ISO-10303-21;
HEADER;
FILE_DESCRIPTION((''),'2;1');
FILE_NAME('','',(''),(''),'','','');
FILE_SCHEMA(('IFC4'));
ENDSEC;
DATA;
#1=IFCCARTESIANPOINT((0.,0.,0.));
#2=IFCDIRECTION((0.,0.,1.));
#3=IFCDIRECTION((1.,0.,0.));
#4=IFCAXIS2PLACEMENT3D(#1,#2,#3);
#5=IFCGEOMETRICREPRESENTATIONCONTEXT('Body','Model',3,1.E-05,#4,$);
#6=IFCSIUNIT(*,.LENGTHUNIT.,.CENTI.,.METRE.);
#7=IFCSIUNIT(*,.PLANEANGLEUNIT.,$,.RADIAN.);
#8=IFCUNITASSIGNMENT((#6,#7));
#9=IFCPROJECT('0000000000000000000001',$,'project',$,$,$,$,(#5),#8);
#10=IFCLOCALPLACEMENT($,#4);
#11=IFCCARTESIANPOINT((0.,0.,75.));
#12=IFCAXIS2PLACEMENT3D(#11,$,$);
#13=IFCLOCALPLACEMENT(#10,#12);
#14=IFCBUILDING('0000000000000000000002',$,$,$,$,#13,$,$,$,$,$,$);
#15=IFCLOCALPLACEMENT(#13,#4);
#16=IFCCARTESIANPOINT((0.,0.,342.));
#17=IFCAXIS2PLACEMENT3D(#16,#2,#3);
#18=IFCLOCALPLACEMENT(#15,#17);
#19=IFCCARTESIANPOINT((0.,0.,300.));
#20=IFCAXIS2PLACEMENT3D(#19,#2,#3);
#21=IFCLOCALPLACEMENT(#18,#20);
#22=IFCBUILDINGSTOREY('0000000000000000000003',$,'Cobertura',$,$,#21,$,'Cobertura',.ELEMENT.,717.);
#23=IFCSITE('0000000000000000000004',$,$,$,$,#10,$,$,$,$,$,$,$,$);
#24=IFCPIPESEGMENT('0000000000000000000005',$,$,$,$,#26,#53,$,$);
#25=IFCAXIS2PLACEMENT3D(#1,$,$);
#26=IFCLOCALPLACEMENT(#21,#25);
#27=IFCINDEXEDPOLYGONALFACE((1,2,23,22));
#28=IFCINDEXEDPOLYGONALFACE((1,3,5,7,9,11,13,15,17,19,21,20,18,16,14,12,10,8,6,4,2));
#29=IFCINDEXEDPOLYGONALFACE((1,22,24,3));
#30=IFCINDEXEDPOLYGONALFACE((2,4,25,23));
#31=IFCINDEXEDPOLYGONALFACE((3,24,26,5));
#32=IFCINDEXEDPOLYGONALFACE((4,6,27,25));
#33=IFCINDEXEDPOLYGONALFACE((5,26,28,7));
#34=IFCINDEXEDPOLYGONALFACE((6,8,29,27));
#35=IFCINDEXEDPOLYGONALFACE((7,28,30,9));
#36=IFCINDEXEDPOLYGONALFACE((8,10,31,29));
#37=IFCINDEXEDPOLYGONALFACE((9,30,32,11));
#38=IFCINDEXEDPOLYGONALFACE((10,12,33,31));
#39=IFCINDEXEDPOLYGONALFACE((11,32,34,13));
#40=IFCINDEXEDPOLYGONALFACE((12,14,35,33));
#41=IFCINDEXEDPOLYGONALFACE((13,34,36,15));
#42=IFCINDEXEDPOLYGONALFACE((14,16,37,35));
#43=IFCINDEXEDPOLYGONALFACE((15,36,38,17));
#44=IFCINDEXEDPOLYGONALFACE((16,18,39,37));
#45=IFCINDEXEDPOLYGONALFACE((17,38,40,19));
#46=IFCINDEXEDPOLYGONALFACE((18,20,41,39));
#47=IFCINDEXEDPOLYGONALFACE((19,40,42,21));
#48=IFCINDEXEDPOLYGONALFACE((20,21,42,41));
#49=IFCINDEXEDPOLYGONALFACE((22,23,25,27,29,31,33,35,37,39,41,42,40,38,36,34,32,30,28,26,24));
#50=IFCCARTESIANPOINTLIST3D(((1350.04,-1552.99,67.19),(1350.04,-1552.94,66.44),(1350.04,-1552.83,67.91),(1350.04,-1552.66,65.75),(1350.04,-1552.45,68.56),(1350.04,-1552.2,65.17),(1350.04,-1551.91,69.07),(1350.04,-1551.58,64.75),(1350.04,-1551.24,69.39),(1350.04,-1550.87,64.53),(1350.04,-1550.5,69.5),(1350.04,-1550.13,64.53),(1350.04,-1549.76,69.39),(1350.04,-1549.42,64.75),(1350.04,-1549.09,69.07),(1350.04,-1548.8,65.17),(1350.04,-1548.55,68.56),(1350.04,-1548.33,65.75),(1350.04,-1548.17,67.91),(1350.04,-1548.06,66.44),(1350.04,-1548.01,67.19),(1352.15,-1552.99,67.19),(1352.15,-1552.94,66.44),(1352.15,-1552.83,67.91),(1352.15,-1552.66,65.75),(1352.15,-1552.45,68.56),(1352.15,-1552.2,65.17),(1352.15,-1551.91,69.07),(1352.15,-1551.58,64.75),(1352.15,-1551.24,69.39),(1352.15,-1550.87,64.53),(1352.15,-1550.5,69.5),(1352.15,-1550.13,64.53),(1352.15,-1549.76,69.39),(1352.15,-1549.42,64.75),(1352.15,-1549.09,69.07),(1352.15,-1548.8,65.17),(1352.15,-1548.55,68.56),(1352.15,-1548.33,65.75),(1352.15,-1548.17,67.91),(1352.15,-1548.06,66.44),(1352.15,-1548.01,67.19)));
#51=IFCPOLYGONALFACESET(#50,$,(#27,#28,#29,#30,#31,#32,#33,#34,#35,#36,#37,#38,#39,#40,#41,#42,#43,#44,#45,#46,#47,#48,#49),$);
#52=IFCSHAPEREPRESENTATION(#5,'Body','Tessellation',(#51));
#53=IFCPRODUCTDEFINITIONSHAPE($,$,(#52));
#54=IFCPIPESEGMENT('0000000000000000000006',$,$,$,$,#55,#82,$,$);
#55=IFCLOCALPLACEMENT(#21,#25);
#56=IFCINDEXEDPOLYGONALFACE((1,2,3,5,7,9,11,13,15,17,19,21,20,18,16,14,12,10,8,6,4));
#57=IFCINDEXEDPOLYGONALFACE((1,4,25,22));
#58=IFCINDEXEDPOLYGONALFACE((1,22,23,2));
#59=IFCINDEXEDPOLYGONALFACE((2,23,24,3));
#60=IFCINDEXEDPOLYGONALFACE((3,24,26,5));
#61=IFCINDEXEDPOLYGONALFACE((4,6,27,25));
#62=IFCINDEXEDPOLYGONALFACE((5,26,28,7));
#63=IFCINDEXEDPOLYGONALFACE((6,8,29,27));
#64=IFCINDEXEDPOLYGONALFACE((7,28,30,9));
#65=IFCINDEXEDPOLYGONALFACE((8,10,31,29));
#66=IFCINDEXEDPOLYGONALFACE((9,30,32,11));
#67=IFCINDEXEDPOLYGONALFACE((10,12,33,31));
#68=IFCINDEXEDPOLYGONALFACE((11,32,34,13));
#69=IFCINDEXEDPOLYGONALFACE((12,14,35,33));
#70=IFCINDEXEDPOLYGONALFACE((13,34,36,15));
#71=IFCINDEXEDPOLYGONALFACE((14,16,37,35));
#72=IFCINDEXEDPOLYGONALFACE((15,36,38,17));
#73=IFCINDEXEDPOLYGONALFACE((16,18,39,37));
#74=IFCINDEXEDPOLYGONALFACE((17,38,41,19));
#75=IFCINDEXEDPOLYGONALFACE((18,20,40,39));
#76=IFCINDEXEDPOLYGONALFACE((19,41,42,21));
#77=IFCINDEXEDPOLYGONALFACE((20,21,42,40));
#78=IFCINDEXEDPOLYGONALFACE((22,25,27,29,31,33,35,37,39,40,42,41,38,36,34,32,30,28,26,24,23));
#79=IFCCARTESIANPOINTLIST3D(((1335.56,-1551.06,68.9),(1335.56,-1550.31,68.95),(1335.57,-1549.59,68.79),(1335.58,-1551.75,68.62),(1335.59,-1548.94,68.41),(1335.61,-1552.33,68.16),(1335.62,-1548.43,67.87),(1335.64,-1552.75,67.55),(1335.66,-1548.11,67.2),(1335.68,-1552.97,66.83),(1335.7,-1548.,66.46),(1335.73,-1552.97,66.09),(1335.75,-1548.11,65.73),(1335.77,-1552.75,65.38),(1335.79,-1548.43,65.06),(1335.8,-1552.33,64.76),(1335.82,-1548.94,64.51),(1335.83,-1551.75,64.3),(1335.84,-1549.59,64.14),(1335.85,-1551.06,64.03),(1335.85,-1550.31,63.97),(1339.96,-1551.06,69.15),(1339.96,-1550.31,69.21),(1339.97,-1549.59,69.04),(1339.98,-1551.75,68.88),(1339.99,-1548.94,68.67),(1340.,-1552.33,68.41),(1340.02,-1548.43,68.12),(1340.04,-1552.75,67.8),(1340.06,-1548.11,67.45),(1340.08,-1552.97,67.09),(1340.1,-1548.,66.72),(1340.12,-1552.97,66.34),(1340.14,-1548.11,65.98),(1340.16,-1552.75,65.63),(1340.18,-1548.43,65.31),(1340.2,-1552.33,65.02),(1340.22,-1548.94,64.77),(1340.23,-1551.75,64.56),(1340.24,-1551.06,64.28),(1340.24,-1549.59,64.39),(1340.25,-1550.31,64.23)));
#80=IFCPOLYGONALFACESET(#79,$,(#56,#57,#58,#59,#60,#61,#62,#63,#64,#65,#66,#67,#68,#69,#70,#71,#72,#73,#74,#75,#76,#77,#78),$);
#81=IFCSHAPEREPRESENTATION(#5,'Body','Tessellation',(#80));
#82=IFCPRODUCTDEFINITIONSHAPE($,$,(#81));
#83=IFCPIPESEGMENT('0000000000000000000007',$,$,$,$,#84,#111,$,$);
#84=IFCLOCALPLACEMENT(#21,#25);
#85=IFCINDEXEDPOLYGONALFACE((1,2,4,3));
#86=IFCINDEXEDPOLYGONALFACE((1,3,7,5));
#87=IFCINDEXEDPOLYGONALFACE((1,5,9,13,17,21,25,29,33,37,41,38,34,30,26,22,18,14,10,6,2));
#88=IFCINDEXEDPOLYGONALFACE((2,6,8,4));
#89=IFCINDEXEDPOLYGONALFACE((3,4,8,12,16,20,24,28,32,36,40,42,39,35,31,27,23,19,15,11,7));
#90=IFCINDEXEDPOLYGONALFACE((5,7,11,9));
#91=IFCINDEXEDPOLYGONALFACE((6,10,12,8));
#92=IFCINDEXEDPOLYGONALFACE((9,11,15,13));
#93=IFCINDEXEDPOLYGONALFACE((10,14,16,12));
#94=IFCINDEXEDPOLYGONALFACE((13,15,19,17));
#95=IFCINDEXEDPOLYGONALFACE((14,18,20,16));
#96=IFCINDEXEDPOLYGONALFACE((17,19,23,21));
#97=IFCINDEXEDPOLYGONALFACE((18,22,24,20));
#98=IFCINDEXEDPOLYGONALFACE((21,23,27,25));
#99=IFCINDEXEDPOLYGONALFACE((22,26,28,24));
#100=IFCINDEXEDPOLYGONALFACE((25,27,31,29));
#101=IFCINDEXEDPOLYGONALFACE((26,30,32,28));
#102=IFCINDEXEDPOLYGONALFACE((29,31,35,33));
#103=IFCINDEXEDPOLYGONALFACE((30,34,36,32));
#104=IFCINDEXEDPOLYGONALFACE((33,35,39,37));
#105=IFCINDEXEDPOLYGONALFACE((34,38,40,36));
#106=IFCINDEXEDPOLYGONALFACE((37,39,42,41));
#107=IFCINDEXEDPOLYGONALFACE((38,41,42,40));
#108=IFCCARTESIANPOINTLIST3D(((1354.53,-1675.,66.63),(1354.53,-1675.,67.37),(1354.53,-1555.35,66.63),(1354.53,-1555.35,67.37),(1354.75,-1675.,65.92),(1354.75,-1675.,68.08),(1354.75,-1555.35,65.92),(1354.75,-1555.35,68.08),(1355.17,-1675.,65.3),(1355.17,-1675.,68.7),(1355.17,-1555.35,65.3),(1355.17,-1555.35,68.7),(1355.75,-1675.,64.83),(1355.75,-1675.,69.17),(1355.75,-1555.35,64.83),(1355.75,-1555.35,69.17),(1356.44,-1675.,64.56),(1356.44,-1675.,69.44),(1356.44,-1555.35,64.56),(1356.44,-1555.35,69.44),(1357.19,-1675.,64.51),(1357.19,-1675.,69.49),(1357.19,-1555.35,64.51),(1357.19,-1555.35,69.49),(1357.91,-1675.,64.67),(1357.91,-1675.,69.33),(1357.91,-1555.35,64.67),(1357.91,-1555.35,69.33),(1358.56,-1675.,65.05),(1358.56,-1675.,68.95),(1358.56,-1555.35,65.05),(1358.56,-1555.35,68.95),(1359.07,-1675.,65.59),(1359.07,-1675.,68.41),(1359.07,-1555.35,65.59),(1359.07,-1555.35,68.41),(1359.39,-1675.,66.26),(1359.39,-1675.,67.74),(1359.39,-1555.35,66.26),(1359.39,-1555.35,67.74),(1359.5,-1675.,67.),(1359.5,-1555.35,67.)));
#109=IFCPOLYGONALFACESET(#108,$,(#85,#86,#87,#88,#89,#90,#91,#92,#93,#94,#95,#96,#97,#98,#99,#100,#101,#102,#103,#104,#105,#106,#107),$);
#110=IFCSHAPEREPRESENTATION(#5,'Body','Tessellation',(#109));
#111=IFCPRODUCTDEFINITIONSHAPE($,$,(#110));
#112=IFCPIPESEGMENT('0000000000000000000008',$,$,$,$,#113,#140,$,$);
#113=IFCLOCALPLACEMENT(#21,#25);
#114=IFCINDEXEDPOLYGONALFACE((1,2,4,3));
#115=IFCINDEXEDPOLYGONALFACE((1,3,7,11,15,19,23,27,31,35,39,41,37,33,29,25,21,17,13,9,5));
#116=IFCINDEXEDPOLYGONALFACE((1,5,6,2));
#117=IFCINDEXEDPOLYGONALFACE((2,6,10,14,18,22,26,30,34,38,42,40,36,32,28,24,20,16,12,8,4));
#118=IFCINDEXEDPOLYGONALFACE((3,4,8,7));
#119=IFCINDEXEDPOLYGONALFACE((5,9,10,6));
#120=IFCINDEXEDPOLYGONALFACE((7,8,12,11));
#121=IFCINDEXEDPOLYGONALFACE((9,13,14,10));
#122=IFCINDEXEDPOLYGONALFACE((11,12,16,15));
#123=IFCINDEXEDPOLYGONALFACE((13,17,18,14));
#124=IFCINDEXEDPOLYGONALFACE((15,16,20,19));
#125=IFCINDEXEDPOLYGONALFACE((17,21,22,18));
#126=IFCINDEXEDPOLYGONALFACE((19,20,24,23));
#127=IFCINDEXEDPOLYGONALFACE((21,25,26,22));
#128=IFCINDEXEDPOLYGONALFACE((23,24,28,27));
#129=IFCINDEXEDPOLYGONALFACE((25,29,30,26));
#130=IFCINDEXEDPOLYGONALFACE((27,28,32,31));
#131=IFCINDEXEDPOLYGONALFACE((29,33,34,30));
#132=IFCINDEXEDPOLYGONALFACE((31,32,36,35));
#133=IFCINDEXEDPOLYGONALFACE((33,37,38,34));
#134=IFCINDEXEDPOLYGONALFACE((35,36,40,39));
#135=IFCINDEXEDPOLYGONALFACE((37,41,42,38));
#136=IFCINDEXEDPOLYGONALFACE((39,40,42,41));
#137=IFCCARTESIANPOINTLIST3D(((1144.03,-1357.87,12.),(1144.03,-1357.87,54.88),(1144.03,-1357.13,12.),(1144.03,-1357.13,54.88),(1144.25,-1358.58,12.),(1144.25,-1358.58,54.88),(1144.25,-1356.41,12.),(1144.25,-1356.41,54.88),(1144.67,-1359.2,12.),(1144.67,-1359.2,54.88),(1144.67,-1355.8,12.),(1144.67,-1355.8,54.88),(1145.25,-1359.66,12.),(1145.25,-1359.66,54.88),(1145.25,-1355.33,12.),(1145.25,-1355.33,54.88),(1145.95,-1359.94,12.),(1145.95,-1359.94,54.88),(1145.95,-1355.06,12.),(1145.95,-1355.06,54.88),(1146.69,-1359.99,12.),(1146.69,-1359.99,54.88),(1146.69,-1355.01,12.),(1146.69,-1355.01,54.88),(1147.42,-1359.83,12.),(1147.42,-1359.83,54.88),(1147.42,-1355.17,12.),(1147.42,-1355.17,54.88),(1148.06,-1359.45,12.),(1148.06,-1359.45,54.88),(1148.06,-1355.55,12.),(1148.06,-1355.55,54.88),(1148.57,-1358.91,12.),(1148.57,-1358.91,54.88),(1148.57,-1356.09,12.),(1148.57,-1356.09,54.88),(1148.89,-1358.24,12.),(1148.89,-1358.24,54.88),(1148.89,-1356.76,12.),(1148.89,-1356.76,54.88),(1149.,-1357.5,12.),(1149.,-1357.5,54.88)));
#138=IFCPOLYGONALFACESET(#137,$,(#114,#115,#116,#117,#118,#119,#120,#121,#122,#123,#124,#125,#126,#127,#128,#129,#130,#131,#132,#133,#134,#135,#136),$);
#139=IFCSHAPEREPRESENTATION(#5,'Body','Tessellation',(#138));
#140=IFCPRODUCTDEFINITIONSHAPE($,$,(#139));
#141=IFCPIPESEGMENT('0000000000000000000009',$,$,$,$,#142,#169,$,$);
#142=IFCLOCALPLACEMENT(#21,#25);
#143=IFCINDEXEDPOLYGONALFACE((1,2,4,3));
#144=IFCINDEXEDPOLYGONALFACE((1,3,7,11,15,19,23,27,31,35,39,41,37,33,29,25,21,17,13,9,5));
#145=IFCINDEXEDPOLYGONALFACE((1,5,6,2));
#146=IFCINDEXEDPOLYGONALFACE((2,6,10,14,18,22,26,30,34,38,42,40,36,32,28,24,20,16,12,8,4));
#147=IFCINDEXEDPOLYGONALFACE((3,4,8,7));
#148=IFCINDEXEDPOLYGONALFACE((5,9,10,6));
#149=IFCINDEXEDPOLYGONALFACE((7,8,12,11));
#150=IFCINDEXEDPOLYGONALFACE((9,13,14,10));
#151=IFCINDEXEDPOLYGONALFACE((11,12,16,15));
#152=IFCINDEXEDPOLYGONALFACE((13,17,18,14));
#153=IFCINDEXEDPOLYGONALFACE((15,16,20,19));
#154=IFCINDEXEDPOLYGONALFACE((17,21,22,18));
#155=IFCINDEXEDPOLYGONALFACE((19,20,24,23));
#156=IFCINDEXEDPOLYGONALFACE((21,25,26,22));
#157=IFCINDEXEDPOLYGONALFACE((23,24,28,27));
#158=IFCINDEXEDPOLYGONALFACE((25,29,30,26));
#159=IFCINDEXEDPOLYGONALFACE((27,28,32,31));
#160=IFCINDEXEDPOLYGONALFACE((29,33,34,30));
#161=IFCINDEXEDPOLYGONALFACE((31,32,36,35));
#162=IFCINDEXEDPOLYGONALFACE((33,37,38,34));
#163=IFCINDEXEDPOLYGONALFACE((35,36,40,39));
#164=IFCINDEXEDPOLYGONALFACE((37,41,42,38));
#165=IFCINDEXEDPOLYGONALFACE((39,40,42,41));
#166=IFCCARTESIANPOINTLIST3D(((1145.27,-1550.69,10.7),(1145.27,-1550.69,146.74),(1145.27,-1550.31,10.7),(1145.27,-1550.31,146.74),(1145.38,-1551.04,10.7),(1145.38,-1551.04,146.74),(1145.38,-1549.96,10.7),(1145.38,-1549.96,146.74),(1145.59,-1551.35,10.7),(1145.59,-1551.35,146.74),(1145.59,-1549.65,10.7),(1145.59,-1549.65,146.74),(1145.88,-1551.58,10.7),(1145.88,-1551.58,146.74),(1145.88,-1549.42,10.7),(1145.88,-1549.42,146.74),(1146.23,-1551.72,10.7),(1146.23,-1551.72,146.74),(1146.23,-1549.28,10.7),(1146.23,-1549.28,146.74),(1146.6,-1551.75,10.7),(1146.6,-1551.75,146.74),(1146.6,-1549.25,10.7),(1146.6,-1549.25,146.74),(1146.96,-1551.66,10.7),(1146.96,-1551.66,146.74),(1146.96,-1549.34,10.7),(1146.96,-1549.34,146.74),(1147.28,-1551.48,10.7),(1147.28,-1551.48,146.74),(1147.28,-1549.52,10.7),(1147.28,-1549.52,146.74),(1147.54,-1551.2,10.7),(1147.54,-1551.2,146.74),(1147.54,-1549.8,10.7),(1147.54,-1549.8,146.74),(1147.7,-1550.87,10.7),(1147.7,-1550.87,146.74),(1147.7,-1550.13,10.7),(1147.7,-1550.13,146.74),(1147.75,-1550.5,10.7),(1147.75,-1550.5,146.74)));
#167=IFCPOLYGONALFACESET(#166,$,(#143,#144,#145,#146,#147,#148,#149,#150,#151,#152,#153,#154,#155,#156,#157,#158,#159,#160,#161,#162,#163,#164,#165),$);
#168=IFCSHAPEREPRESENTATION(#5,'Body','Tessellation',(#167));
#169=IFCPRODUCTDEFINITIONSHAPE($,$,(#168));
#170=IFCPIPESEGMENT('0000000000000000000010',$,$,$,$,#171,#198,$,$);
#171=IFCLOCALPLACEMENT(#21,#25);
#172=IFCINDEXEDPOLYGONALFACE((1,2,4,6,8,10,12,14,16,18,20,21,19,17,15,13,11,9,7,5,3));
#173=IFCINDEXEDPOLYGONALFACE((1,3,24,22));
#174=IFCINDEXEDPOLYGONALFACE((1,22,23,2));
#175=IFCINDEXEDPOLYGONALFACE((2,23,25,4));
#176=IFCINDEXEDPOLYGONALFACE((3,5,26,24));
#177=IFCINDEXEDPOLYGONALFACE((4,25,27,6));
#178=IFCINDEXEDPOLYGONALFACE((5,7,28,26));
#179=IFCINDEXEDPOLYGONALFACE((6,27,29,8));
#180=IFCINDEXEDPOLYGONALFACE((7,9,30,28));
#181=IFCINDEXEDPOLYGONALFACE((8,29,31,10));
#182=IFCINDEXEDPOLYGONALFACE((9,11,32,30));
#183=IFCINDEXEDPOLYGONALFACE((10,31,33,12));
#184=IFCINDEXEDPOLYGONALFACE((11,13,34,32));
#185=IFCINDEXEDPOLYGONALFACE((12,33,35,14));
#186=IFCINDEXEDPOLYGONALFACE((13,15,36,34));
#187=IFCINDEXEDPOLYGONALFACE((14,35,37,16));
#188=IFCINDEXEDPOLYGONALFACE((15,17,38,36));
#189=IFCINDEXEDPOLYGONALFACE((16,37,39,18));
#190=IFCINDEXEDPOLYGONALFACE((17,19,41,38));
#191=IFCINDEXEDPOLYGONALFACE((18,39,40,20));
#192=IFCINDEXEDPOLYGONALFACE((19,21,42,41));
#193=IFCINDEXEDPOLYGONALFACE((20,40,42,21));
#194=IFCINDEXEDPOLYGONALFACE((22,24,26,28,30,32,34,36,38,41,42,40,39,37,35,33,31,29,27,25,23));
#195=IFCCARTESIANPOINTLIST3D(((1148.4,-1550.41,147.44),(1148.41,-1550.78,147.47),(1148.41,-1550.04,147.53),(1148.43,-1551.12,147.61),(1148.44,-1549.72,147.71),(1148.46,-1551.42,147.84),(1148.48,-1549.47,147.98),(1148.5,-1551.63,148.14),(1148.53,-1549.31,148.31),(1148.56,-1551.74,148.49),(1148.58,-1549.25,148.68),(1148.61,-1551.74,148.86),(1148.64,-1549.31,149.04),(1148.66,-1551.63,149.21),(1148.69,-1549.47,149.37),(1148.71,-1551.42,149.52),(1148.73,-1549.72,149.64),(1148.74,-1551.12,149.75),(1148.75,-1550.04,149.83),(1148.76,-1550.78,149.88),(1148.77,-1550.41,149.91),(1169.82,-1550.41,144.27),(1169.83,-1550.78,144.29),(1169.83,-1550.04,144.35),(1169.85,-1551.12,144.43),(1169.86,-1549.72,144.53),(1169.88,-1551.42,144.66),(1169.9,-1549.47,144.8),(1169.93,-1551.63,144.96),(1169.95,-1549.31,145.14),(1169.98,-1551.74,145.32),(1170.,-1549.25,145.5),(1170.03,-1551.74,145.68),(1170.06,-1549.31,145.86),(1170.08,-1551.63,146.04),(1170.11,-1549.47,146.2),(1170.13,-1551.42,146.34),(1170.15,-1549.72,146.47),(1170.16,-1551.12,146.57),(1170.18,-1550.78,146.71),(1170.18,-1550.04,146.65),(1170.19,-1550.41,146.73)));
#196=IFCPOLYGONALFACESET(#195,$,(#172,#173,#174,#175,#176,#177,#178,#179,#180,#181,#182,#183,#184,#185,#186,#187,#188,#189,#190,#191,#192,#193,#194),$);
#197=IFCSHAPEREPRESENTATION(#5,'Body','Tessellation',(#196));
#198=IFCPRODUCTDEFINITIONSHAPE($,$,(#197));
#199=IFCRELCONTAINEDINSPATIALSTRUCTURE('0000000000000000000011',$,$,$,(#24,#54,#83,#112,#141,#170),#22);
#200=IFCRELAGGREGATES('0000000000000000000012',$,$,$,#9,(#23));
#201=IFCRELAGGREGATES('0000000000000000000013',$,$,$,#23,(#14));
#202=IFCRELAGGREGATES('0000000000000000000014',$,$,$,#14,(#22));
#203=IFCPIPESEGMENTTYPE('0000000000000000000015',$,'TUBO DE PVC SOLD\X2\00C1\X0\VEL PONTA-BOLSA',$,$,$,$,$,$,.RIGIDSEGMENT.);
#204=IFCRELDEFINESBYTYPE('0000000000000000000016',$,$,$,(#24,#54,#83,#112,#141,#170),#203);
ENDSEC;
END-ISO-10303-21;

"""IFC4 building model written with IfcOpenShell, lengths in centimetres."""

from ifc_helpers import new_model, si_unit, frame, origin_with_axes, origin_2d_with_axis, place, context, project, spatial, circle, extrude, type_object, element, save


model = new_model("IFC4")

# Units and contexts
model_context = context("Model", 3, precision=1e-05, world=origin_with_axes(), identifier="Body")
ifc_project = project(units=[si_unit("LENGTHUNIT", "METRE", prefix="CENTI"), si_unit("PLANEANGLEUNIT", "RADIAN")], contexts=[model_context])

# Site, building, storey
site_placement = place(None, origin_with_axes())
site = spatial("IfcSite", under=ifc_project, at=site_placement)
building_placement = place(site_placement, frame((0.0, 0.0, 75.0)))
building = spatial("IfcBuilding", under=site, at=building_placement)
placement_1 = place(building_placement, origin_with_axes())
placement_2 = place(placement_1, frame((0.0, 0.0, 342.0), z_axis=(0.0, 0.0, 1.0), x_axis=(1.0, 0.0, 0.0)))
storey_placement = place(placement_2, frame((0.0, 0.0, 300.0), z_axis=(0.0, 0.0, 1.0), x_axis=(1.0, 0.0, 0.0)))
storey = spatial("IfcBuildingStorey", under=building, at=storey_placement, Name="Cobertura", LongName="Cobertura", CompositionType="ELEMENT", Elevation=717.0)

# Pipe segments
pipe_segment_type_1 = type_object("IfcPipeSegmentType", Name="TUBO DE PVC SOLDÁVEL PONTA-BOLSA", PredefinedType="RIGIDSEGMENT")
pipe_segment_1_placement = place(storey_placement, frame((1351.1, -1550.5, 69.5), z_axis=(0.0, 0.0, 1.0), x_axis=(1.0, 0.0, 0.0)))
element("IfcPipeSegment", 1, at=pipe_segment_1_placement, inside=storey, type_object=pipe_segment_type_1, context=model_context, shape_type="SolidModel", body=[
    extrude(circle(Radius=2.5, at=origin_2d_with_axis()), frame((-1.06, 0.0, -2.5), z_axis=(1.0, 0.000028, 0.0), x_axis=(0.0, 0.0, 1.0)), (0.0, 0.0, 1.0), 2.11),
])
pipe_segment_2_placement = place(storey_placement, frame((1337.9, -1550.5, 69.21), z_axis=(0.0, 0.0, 1.0), x_axis=(1.0, 0.0, 0.0)))
element("IfcPipeSegment", 2, at=pipe_segment_2_placement, inside=storey, type_object=pipe_segment_type_1, context=model_context, shape_type="SolidModel", body=[
    extrude(circle(Radius=2.5, at=origin_2d_with_axis()), frame((-2.2, 0.0, -2.75), z_axis=(0.998333, 0.0, 0.05771), x_axis=(0.0, 1.0, 0.000134)), (0.0, 0.0, 1.0), 4.4),
])
pipe_segment_3_placement = place(storey_placement, frame((1357.0, -1615.17, 69.5), z_axis=(0.0, 0.0, 1.0), x_axis=(1.0, 0.0, 0.0)))
element("IfcPipeSegment", 3, at=pipe_segment_3_placement, inside=storey, type_object=pipe_segment_type_1, context=model_context, shape_type="SolidModel", body=[
    extrude(circle(Radius=2.5, at=origin_2d_with_axis()), frame((0.0, 59.83, -2.5), z_axis=(0.0, -1.0, 0.0), x_axis=(1.0, 0.0, 0.0)), (0.0, 0.0, 1.0), 119.65),
])
pipe_segment_4_placement = place(storey_placement, frame((1146.5, -1357.5, 54.88), z_axis=(0.0, 0.0, 1.0), x_axis=(1.0, 0.0, 0.0)))
element("IfcPipeSegment", 4, at=pipe_segment_4_placement, inside=storey, type_object=pipe_segment_type_1, context=model_context, shape_type="SolidModel", body=[
    extrude(circle(Radius=2.5, at=origin_2d_with_axis()), frame((0.0, 0.0, 0.0), z_axis=(0.0, 0.0, -1.0), x_axis=(1.0, 0.0, 0.0)), (0.0, 0.0, 1.0), 42.88),
])
pipe_segment_5_placement = place(storey_placement, frame((1146.5, -1550.5, 146.74), z_axis=(0.0, 0.0, 1.0), x_axis=(1.0, 0.0, 0.0)))
element("IfcPipeSegment", 5, at=pipe_segment_5_placement, inside=storey, type_object=pipe_segment_type_1, context=model_context, shape_type="SolidModel", body=[
    extrude(circle(Radius=1.25, at=origin_2d_with_axis()), frame((0.0, 0.0, -136.04), z_axis=(0.0, 0.0, 1.0), x_axis=(1.0, 0.0, 0.0)), (0.0, 0.0, 1.0), 136.04),
])
pipe_segment_6_placement = place(storey_placement, frame((1159.29, -1550.5, 149.91), z_axis=(0.0, 0.0, 1.0), x_axis=(1.0, 0.0, 0.0)))
element("IfcPipeSegment", 6, at=pipe_segment_6_placement, inside=storey, type_object=pipe_segment_type_1, context=model_context, shape_type="SolidModel", body=[
    extrude(circle(Radius=1.25, at=origin_2d_with_axis()), frame((-10.71, 0.0, -1.24), z_axis=(0.989175, 0.0, -0.146739), x_axis=(0.0, 1.0, 0.0)), (0.0, 0.0, 1.0), 21.66),
])

save(model, "model.ifc")
